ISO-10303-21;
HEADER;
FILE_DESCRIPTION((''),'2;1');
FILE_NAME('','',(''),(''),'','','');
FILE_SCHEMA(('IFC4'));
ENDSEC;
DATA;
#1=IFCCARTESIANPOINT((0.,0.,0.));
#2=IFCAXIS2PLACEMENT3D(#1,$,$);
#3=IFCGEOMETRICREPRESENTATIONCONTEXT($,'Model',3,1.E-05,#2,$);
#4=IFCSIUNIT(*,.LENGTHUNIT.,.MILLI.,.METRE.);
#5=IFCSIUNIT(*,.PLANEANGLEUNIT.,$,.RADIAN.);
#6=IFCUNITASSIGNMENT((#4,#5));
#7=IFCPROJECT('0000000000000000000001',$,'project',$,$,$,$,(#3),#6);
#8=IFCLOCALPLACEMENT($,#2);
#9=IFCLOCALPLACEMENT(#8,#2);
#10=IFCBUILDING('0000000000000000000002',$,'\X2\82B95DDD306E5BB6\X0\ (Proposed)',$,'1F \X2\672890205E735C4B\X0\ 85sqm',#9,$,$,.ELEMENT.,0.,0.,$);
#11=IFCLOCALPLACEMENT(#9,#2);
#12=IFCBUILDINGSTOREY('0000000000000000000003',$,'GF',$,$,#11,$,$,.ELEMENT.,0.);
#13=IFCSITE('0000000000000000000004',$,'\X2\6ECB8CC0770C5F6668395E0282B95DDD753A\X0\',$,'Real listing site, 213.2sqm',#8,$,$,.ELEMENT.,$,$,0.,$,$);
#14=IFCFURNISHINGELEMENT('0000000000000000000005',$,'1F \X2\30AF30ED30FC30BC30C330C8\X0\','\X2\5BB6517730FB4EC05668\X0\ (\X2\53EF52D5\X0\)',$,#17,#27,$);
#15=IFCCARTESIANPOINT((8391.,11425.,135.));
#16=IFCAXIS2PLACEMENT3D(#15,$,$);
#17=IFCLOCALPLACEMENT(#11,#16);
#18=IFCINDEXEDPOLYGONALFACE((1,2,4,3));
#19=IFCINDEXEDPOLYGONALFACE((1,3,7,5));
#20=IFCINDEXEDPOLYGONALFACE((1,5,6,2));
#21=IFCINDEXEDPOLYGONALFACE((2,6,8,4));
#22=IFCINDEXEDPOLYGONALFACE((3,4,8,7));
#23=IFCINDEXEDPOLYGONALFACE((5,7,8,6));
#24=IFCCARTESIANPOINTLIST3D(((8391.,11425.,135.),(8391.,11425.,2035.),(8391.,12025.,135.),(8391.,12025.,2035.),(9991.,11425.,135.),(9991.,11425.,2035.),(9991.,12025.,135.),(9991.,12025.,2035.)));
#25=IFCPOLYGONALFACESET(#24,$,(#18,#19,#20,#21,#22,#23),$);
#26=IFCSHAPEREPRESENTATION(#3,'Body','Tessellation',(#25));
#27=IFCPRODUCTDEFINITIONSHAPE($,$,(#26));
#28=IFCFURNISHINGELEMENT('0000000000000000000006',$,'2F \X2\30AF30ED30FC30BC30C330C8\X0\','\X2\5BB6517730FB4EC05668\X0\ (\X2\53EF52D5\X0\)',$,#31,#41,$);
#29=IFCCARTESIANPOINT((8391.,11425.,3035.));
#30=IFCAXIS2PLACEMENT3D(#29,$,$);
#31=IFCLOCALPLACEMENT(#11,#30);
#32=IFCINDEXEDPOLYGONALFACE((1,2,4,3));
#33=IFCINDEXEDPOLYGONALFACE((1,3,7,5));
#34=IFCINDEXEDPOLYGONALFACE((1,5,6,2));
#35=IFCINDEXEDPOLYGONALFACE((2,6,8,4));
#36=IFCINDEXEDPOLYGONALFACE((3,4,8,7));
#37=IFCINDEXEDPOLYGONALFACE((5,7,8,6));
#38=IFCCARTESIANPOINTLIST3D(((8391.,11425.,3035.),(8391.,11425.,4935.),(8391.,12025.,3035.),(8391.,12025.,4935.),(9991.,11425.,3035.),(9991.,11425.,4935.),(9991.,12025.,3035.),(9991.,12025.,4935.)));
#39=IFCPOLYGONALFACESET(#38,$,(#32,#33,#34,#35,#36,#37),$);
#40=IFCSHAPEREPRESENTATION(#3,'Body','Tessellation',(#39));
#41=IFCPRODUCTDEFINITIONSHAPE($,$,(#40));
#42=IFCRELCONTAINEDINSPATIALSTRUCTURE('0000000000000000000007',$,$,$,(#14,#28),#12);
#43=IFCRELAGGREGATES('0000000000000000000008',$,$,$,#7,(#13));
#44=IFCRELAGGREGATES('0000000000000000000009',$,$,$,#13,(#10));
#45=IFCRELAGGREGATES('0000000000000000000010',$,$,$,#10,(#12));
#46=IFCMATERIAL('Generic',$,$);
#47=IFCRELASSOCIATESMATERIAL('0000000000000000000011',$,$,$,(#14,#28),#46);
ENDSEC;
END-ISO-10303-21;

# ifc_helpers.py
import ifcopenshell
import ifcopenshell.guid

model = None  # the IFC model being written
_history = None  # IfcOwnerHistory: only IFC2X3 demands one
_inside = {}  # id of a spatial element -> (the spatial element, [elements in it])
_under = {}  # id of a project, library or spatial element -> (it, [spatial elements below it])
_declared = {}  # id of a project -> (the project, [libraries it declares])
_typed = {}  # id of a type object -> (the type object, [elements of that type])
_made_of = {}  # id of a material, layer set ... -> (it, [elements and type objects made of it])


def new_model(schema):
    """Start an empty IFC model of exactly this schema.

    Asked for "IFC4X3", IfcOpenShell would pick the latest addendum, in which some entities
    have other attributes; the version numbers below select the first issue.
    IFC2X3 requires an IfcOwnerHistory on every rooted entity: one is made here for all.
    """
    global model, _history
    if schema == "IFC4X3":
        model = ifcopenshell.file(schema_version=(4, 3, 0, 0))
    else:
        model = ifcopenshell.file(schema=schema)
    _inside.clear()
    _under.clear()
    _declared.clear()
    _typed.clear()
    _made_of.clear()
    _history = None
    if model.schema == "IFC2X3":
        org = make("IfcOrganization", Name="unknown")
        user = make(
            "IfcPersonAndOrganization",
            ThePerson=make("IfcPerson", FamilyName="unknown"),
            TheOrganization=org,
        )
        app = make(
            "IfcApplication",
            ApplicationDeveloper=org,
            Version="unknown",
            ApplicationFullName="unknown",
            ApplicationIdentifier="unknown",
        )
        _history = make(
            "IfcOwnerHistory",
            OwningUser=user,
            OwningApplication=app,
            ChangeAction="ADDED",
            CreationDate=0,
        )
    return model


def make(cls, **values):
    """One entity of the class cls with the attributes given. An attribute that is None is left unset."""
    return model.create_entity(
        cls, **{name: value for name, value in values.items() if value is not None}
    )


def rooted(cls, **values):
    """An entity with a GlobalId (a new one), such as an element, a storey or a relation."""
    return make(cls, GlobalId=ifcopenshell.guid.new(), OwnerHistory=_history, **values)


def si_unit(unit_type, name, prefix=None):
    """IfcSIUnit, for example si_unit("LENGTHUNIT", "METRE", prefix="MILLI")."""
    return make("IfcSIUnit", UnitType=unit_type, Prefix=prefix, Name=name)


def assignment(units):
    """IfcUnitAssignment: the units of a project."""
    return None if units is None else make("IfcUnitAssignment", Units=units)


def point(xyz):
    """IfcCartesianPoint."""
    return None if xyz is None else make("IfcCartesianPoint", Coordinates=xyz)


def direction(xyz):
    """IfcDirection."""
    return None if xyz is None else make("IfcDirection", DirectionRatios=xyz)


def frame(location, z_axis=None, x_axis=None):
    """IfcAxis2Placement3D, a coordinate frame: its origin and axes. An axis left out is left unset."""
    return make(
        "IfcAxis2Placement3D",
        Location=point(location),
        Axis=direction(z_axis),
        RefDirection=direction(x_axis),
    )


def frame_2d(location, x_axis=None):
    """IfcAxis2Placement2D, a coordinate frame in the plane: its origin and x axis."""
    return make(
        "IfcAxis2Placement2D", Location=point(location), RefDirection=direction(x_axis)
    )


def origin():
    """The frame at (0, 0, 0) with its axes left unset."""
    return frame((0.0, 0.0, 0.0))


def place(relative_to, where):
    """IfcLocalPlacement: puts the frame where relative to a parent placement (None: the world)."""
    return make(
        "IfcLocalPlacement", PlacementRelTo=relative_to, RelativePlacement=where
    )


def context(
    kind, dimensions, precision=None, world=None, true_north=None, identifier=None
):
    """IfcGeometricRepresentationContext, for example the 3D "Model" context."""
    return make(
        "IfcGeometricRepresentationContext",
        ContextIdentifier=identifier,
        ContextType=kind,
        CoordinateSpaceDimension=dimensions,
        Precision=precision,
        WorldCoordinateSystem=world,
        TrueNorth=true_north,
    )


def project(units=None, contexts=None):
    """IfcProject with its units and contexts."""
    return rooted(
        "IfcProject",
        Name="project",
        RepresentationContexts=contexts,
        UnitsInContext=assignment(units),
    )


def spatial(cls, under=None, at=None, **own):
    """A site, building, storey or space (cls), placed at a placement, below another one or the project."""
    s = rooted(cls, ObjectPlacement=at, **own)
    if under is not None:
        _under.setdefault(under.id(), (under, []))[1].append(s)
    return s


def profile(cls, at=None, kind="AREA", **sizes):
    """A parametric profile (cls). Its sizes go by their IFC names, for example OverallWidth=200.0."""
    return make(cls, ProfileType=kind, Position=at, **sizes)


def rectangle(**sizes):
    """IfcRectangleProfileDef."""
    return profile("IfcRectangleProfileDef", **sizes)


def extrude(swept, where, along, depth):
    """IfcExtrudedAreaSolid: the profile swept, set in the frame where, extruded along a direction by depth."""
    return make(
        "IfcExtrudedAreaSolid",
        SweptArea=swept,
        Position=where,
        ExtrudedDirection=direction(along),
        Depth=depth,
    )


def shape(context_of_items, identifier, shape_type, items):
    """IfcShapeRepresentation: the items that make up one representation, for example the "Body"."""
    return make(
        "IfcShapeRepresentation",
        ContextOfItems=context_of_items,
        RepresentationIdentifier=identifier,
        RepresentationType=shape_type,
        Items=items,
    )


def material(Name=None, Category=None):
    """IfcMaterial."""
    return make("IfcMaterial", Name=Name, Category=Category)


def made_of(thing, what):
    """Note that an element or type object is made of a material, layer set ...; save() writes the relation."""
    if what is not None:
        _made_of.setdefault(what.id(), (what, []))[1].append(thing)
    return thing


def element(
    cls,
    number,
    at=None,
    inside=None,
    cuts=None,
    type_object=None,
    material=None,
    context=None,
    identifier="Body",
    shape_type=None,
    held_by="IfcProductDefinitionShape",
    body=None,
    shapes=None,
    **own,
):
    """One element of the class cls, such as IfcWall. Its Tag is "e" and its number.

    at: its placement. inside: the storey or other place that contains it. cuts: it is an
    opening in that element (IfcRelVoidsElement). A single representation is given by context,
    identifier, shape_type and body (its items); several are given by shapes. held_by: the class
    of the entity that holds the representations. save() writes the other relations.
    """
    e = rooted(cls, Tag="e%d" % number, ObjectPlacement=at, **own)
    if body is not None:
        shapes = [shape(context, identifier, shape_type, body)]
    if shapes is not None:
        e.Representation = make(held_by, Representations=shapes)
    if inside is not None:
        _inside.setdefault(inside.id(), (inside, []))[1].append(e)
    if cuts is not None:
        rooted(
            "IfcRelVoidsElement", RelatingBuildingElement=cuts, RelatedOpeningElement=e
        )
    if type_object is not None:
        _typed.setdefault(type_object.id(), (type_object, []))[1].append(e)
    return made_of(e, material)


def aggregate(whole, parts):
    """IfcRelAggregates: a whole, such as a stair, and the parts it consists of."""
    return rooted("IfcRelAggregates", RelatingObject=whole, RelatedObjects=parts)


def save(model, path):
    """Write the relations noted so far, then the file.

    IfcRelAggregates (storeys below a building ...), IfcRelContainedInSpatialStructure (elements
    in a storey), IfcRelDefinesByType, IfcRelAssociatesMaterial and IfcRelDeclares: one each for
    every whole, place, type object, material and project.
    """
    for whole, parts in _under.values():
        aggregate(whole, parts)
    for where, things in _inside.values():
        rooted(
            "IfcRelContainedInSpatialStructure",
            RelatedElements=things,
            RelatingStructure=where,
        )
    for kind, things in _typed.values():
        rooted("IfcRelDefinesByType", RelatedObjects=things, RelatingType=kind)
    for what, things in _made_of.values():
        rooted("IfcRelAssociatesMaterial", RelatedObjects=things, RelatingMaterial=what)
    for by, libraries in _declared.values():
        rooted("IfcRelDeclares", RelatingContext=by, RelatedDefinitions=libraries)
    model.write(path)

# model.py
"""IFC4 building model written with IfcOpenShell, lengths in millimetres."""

from ifc_helpers import new_model, si_unit, frame, frame_2d, origin, place, context, project, spatial, rectangle, extrude, material, element, save


model = new_model("IFC4")

# Units and contexts
model_context = context("Model", 3, precision=1e-05, world=origin())
ifc_project = project(units=[si_unit("LENGTHUNIT", "METRE", prefix="MILLI"), si_unit("PLANEANGLEUNIT", "RADIAN")], contexts=[model_context])

# Site, building, storey
site_placement = place(None, origin())
site = spatial("IfcSite", under=ifc_project, at=site_placement, Name="滋賀県彦根市芹川町", ObjectType="Real listing site, 213.2sqm", CompositionType="ELEMENT", RefElevation=0.0)
building_placement = place(site_placement, origin())
building = spatial("IfcBuilding", under=site, at=building_placement, Name="芹川の家 (Proposed)", ObjectType="1F 木造平屋 85sqm", CompositionType="ELEMENT", ElevationOfRefHeight=0.0, ElevationOfTerrain=0.0)
storey_placement = place(building_placement, origin())
storey = spatial("IfcBuildingStorey", under=building, at=storey_placement, Name="GF", CompositionType="ELEMENT", Elevation=0.0)

# Shared definitions
ifc_material_1 = material(Name="Generic")

# Furnishing elements
furnishing_1_placement = place(storey_placement, frame((8391.0, 11425.0, 135.0)))
element("IfcFurnishingElement", 1, at=furnishing_1_placement, inside=storey, material=ifc_material_1, Name="1F クローゼット", Description="家具・什器 (可動)", context=model_context, shape_type="SweptSolid", body=[
    extrude(rectangle(XDim=1600.0, YDim=600.0, at=frame_2d((800.0, 300.0))), frame((8391.0, 11425.0, 135.0)), (0.0, 0.0, 1.0), 1900.0),
])
furnishing_2_placement = place(storey_placement, frame((8391.0, 11425.0, 3035.0)))
element("IfcFurnishingElement", 2, at=furnishing_2_placement, inside=storey, material=ifc_material_1, Name="2F クローゼット", Description="家具・什器 (可動)", context=model_context, shape_type="SweptSolid", body=[
    extrude(rectangle(XDim=1600.0, YDim=600.0, at=frame_2d((800.0, 300.0))), frame((8391.0, 11425.0, 3035.0)), (0.0, 0.0, 1.0), 1900.0),
])

save(model, "model.ifc")
